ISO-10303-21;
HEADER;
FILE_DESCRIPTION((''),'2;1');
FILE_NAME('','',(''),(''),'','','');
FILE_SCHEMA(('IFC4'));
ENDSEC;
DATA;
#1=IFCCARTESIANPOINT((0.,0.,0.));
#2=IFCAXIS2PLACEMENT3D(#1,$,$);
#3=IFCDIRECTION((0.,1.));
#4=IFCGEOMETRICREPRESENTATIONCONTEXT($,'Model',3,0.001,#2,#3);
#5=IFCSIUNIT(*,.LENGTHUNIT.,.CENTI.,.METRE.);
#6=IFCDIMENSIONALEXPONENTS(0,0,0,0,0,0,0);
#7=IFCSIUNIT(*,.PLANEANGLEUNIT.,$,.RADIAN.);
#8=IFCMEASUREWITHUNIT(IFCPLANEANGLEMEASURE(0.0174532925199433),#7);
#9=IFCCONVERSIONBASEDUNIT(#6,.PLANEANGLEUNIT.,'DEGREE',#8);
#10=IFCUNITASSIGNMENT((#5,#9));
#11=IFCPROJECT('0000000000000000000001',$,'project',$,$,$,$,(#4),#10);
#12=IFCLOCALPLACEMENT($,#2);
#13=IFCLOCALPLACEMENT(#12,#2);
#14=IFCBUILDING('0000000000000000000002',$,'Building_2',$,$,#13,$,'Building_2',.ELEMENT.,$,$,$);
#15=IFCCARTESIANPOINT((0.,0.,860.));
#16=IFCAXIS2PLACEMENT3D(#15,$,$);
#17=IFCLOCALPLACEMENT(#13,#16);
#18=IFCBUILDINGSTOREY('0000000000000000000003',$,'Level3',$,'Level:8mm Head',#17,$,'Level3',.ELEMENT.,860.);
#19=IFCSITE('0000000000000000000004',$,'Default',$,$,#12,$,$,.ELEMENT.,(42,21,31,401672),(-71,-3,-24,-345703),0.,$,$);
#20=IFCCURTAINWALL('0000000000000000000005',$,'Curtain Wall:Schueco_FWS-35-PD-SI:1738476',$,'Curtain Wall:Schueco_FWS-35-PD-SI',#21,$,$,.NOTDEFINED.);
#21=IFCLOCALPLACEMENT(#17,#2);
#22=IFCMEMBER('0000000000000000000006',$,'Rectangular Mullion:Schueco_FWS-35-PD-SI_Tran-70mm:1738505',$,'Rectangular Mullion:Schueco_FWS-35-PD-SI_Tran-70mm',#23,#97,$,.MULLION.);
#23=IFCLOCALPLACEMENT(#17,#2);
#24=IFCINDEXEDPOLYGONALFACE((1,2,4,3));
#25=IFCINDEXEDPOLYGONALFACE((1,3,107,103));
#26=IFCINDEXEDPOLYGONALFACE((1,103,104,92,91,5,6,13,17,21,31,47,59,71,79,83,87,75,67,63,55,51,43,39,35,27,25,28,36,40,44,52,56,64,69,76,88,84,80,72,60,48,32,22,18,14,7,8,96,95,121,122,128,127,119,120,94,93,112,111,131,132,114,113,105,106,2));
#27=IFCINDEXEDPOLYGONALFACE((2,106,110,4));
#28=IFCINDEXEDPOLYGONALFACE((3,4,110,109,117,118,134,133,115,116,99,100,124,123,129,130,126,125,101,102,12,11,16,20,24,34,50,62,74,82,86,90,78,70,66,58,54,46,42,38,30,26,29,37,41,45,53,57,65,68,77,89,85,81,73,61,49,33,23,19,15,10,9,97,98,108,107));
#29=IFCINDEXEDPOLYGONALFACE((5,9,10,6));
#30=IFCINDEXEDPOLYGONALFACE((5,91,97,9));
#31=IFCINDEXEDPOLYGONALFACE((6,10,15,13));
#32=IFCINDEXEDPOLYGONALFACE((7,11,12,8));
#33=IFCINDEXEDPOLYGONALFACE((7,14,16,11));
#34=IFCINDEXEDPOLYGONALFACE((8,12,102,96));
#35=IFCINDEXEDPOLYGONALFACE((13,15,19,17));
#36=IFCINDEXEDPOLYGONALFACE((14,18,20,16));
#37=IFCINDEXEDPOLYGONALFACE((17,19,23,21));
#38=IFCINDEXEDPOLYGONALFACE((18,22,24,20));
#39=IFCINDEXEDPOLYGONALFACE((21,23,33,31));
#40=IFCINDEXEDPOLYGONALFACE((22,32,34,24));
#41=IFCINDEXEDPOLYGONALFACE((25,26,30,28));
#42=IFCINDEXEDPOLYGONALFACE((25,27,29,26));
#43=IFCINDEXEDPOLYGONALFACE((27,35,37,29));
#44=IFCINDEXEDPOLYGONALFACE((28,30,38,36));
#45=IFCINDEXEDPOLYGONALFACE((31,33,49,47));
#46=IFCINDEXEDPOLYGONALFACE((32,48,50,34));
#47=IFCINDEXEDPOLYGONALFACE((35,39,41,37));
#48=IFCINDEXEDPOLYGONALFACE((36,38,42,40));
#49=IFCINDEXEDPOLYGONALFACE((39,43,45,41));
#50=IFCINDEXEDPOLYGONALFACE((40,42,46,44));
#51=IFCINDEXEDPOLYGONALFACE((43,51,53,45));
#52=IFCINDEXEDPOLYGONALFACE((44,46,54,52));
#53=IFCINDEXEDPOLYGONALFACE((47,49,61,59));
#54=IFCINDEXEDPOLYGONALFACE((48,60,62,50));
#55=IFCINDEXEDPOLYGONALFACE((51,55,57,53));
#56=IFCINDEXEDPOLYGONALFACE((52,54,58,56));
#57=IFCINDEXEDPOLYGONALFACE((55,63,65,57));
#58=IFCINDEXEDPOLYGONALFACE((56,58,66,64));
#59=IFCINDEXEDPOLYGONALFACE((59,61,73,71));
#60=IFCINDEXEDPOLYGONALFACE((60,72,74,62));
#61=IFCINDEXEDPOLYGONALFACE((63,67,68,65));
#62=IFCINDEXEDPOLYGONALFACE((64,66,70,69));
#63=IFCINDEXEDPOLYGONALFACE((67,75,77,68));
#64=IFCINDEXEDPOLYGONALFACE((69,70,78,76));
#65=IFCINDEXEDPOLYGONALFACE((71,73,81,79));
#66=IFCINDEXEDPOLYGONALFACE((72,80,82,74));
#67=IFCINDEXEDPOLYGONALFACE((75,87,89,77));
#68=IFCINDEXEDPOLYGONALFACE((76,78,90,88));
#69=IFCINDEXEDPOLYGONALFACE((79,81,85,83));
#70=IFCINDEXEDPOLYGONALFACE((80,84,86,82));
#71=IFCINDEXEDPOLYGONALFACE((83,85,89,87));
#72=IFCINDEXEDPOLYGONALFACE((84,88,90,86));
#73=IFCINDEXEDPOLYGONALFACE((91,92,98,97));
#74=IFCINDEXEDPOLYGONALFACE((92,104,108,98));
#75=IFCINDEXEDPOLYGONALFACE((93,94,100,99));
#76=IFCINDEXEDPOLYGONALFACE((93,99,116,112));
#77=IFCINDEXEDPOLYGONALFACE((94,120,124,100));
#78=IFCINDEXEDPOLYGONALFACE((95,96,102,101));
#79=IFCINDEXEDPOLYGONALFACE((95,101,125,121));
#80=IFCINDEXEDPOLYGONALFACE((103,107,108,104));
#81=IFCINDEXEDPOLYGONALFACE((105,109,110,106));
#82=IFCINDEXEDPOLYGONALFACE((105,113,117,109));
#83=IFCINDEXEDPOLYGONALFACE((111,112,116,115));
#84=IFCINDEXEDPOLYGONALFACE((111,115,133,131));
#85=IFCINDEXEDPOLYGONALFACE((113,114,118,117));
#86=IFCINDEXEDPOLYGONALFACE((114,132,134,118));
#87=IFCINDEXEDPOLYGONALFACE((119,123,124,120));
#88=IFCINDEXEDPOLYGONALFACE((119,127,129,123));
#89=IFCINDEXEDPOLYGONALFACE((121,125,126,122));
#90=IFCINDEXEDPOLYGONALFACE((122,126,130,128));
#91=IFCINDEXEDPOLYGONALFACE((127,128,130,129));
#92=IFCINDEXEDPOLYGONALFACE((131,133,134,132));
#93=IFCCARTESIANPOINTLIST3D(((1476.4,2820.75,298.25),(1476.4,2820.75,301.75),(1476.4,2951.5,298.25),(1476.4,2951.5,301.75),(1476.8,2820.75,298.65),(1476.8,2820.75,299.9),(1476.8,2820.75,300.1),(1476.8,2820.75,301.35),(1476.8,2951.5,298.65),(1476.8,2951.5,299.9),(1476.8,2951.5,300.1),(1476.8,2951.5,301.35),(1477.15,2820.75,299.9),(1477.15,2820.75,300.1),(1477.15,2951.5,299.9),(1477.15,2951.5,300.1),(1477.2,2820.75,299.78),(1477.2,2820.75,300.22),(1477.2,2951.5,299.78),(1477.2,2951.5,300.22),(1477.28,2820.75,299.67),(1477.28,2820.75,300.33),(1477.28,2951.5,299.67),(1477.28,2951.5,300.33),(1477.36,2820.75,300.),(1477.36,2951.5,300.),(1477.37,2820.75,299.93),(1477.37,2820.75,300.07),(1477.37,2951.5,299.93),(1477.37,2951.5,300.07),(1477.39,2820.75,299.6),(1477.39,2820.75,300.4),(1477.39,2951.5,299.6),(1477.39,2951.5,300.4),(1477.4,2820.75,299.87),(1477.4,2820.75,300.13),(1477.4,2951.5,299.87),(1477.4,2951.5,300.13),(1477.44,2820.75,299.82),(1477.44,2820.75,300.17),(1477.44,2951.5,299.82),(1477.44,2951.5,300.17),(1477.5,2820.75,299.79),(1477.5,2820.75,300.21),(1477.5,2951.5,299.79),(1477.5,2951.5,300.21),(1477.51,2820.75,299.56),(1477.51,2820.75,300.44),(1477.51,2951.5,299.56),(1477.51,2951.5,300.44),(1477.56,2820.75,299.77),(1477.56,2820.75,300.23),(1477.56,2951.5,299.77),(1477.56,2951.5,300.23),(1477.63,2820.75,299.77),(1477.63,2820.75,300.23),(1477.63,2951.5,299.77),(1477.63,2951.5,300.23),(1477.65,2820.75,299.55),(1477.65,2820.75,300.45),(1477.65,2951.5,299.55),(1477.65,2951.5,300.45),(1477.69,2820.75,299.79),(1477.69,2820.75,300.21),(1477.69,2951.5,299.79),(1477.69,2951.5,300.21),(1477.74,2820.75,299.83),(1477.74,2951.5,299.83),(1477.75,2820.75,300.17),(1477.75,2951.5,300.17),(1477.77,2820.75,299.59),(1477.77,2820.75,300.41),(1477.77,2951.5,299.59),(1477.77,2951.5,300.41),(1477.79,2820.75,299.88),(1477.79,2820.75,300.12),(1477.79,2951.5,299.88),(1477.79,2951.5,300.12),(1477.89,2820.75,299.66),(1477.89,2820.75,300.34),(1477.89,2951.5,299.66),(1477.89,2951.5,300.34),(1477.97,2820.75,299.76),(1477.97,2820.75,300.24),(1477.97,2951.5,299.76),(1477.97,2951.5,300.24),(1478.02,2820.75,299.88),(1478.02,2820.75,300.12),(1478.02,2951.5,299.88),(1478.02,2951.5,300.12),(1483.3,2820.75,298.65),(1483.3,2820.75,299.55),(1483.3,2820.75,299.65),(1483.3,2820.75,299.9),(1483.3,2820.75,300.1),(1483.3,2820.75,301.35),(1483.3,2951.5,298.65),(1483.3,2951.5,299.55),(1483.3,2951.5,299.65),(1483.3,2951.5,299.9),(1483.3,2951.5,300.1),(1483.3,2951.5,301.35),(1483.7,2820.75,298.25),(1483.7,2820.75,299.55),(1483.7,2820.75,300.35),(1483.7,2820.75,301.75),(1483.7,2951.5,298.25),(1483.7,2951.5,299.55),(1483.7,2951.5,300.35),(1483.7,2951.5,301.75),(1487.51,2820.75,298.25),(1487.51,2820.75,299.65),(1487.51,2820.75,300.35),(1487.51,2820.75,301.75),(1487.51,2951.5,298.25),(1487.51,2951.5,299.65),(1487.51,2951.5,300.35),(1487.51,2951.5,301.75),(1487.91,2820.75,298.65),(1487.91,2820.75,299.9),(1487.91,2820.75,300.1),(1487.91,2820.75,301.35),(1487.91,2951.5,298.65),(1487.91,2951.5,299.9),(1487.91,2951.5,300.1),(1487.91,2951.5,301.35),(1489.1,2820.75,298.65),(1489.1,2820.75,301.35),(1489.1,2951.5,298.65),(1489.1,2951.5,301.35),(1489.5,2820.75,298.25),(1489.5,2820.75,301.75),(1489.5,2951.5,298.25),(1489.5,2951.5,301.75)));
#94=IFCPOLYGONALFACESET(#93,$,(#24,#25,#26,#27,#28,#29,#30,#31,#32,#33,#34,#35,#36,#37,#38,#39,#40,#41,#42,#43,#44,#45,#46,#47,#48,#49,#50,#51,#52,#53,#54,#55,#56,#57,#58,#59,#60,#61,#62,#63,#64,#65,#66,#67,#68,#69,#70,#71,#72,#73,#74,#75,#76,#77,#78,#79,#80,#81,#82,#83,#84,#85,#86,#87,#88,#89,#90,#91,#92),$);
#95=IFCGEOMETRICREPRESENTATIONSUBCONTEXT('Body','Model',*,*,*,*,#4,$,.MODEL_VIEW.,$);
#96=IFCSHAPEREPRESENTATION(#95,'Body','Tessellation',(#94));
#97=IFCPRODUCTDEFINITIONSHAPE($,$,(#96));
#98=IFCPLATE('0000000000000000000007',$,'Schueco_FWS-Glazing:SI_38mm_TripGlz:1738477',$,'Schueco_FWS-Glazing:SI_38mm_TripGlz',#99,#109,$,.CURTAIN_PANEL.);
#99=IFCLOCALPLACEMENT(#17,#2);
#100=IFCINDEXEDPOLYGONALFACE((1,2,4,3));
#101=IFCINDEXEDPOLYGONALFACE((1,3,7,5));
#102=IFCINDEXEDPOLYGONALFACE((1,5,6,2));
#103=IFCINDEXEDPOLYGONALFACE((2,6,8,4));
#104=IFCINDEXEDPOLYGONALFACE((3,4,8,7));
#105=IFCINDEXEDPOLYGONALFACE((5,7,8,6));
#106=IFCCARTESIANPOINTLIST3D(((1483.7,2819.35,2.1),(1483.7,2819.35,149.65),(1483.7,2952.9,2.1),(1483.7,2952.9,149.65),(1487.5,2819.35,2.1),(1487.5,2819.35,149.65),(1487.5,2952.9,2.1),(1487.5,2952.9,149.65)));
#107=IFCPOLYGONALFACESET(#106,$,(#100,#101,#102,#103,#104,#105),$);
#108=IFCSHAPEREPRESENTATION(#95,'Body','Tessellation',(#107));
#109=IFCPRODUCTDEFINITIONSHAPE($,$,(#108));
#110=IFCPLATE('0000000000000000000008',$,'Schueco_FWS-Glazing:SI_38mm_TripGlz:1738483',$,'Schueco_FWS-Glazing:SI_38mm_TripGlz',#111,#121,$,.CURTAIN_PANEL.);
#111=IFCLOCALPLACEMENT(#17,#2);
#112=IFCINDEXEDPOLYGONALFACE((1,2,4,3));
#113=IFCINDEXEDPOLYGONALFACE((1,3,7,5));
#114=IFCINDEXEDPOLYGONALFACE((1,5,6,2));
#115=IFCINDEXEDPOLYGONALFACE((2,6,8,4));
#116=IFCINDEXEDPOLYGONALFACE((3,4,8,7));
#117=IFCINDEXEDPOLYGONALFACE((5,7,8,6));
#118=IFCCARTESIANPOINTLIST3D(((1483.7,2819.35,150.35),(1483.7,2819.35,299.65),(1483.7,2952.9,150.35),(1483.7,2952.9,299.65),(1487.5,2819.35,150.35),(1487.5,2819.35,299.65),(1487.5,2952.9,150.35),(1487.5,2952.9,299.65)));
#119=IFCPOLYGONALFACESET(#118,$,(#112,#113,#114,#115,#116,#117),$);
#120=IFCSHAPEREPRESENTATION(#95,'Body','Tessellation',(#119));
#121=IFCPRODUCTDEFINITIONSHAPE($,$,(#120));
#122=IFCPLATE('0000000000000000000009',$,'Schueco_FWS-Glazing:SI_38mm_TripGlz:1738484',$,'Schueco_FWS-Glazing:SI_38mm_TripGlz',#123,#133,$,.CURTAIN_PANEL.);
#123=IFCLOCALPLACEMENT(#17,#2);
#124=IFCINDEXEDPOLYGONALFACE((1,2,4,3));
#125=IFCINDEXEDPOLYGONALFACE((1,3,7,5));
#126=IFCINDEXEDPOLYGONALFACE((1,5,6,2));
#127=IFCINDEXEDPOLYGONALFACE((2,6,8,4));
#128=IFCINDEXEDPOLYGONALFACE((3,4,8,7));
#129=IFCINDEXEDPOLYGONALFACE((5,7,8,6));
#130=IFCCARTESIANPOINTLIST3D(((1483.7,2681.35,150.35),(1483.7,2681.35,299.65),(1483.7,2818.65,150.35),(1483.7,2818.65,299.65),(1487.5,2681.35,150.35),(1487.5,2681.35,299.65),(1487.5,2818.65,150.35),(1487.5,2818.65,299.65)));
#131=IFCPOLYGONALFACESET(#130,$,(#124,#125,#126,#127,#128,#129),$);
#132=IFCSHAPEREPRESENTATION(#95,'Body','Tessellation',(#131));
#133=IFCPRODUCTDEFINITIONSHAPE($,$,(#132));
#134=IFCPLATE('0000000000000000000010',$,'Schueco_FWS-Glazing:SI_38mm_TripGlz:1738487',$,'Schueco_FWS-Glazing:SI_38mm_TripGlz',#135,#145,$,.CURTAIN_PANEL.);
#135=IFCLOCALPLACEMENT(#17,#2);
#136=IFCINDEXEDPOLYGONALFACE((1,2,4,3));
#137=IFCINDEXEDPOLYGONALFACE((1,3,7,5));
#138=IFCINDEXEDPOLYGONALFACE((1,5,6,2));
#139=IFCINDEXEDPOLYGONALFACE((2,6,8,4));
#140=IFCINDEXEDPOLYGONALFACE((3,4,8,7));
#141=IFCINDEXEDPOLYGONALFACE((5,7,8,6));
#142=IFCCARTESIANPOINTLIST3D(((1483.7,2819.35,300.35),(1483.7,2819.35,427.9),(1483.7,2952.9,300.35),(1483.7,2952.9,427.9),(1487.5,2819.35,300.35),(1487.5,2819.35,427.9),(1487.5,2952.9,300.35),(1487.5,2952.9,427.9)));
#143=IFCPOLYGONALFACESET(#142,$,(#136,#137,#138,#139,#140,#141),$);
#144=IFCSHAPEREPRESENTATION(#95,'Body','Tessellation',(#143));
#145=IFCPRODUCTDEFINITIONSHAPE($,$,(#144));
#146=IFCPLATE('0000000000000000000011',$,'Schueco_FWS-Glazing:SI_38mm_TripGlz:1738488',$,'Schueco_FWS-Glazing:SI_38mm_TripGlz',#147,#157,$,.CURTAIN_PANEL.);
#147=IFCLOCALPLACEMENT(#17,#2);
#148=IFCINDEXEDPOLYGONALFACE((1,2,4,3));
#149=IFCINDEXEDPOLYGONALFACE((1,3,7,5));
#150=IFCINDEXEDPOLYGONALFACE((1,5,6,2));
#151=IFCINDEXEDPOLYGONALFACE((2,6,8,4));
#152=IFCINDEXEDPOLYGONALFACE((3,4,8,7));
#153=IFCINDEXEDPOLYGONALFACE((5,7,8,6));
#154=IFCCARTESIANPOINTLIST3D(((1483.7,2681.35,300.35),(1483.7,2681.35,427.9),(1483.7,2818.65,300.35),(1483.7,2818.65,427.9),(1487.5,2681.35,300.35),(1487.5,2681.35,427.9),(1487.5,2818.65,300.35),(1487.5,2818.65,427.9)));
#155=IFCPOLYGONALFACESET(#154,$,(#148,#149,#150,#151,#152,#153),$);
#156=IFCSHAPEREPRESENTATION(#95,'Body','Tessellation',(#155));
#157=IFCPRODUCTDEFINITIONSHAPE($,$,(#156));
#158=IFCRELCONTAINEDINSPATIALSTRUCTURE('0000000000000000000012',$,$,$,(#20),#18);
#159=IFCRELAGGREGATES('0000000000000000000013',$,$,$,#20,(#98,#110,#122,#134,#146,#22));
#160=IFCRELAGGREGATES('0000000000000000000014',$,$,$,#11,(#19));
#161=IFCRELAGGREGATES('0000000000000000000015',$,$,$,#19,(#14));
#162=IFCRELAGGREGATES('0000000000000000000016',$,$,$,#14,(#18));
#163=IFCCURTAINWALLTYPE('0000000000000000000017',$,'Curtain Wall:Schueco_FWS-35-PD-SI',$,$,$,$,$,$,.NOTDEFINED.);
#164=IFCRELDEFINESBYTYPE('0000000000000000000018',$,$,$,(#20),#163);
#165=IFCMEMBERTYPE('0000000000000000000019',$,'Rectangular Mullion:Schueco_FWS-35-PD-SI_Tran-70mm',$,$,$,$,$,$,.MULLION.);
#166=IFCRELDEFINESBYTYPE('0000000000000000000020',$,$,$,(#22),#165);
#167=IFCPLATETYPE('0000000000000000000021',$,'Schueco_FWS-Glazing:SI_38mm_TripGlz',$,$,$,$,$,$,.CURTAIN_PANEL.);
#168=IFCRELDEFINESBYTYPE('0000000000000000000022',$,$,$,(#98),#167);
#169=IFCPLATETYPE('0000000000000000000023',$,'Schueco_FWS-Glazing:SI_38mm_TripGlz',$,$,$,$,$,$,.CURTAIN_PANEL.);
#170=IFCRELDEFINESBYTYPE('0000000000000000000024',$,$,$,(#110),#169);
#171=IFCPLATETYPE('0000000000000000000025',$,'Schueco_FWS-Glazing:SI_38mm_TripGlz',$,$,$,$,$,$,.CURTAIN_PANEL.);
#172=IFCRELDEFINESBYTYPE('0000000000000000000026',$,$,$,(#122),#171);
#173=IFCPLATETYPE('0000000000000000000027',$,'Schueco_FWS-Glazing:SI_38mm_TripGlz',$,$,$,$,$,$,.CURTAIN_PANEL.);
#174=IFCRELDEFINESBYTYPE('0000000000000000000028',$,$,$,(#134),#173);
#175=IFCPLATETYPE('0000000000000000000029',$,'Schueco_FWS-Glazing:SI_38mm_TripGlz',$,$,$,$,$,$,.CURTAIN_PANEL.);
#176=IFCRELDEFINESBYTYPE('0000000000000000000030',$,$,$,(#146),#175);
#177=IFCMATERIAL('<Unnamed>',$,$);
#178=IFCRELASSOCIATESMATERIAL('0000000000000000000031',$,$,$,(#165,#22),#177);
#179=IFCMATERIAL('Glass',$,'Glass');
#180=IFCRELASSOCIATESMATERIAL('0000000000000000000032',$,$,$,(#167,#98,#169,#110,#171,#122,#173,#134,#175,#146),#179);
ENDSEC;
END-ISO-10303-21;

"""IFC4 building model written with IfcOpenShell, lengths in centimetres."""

from ifc_helpers import new_model, entity, si_unit, converted_unit, direction, frame, origin, place, context, subcontext, project, spatial, line, arc, indexed_curve, outline, extrude, source, transform, mapped, material, type_object, type_shapes, element, aggregate, save


model = new_model("IFC4")

# Units and contexts
model_context = context("Model", 3, precision=0.001, world=origin(), true_north=direction((0.0, 1.0)))
body_context = subcontext(model_context, "Body", "Model", "MODEL_VIEW")
ifc_project = project(units=[si_unit("LENGTHUNIT", "METRE", prefix="CENTI"), converted_unit("PLANEANGLEUNIT", "DEGREE", entity("IfcPlaneAngleMeasure", 0.0174532925199433), si_unit("PLANEANGLEUNIT", "RADIAN"), dimensions=[0, 0, 0, 0, 0, 0, 0])], contexts=[model_context])

# Site, building, storey
site_placement = place(None, origin())
site = spatial("IfcSite", under=ifc_project, at=site_placement, Name="Default", CompositionType="ELEMENT", RefLatitude=(42, 21, 31, 401672), RefLongitude=(-71, -3, -24, -345703), RefElevation=0.0)
building_placement = place(site_placement, origin())
building = spatial("IfcBuilding", under=site, at=building_placement, Name="Building_2", LongName="Building_2", CompositionType="ELEMENT")
storey_placement = place(building_placement, frame((0.0, 0.0, 860.0)))
storey = spatial("IfcBuildingStorey", under=building, at=storey_placement, Name="Level3", ObjectType="Level:8mm Head", LongName="Level3", CompositionType="ELEMENT", Elevation=860.0)

# Curtain wall, member, plates
curtain_wall_type = type_object("IfcCurtainWallType", Name="Curtain Wall:Schueco_FWS-35-PD-SI", PredefinedType="NOTDEFINED")
curtain_wall_placement = place(storey_placement, frame((0.0, 0.0, -860.0)))
curtain_wall = element("IfcCurtainWall", 1, at=curtain_wall_placement, inside=storey, type_object=curtain_wall_type, Name="Curtain Wall:Schueco_FWS-35-PD-SI:1738476", ObjectType="Curtain Wall:Schueco_FWS-35-PD-SI", PredefinedType="NOTDEFINED")
ifc_material_1 = material(Name="<Unnamed>")
member_type_1 = type_object("IfcMemberType", Name="Rectangular Mullion:Schueco_FWS-35-PD-SI_Tran-70mm", PredefinedType="MULLION", material=ifc_material_1)
shared_shape_1 = source(origin(), body_context, "Body", "SweptSolid", [
    extrude(outline(indexed_curve([(-1.78, -6.52), (1.72, -6.52), (1.72, 0.78), (0.42, 0.78), (0.42, 0.38), (1.32, 0.38), (1.32, -6.12), (0.07, -6.12), (0.07, -5.77), (0.42, -5.34), (0.09, -4.9), (0.09, -5.14), (-0.03, -5.56), (-0.15, -5.14), (-0.15, -4.9), (-0.48, -5.34), (-0.13, -5.77), (-0.13, -6.12), (-1.38, -6.12), (-1.38, 0.38), (-0.13, 0.38), (-0.13, 4.99), (-1.38, 4.99), (-1.38, 6.18), (1.32, 6.18), (1.32, 4.99), (0.07, 4.99), (0.07, 0.38), (0.32, 0.38), (0.32, 4.59), (1.72, 4.59), (1.72, 6.58), (-1.78, 6.58), (-1.78, 4.59), (-0.38, 4.59), (-0.38, 0.78), (-1.78, 0.78)], segments=[line(1, 2, 3, 4, 5, 6, 7, 8, 9), arc(9, 10, 11), line(11, 12), arc(12, 13, 14), line(14, 15), arc(15, 16, 17), line(17, 18, 19, 20, 21, 22, 23, 24, 25, 26, 27, 28, 29, 30, 31, 32, 33, 34, 35, 36, 37, 1)], self_intersect=False)), frame((-0.03, 4.58, -130.75), z_axis=(0.0, 0.0, 1.0), x_axis=(-1.0, 0.0, 0.0)), (0.0, 0.0, 1.0), 130.75),
])
type_shapes(member_type_1, [shared_shape_1])
member_1_placement = place(curtain_wall_placement, frame((1487.5, 2820.75, 1160.0), z_axis=(0.0, -1.0, 0.0), x_axis=(0.0, 0.0, 1.0)))
member_1 = element("IfcMember", 2, at=member_1_placement, type_object=member_type_1, material=ifc_material_1, Name="Rectangular Mullion:Schueco_FWS-35-PD-SI_Tran-70mm:1738505", ObjectType="Rectangular Mullion:Schueco_FWS-35-PD-SI_Tran-70mm", PredefinedType="MULLION", context=body_context, shape_type="MappedRepresentation", body=[
    mapped(shared_shape_1, transform((0.0, 0.0, 0.0), scale=1.0)),
])
ifc_material_2 = material(Name="Glass", Category="Glass")
plate_type_1 = type_object("IfcPlateType", Name="Schueco_FWS-Glazing:SI_38mm_TripGlz", PredefinedType="CURTAIN_PANEL", material=ifc_material_2)
shared_shape_2 = source(origin(), body_context, "Body", "SweptSolid", [
    extrude(outline(indexed_curve([(-1.9, -66.78), (1.9, -66.78), (1.9, 66.78), (-1.9, 66.78), (-1.9, -66.78)], self_intersect=False)), frame((0.0, -1.9, 0.0), z_axis=(0.0, 0.0, 1.0), x_axis=(0.0, 1.0, 0.0)), (0.0, 0.0, 1.0), 147.55),
])
type_shapes(plate_type_1, [shared_shape_2])
plate_1_placement = place(curtain_wall_placement, frame((1487.5, 2886.12, 862.1), z_axis=(0.0, 0.0, 1.0), x_axis=(0.0, -1.0, 0.0)))
plate_1 = element("IfcPlate", 3, at=plate_1_placement, type_object=plate_type_1, material=ifc_material_2, Name="Schueco_FWS-Glazing:SI_38mm_TripGlz:1738477", ObjectType="Schueco_FWS-Glazing:SI_38mm_TripGlz", PredefinedType="CURTAIN_PANEL", context=body_context, shape_type="MappedRepresentation", body=[
    mapped(shared_shape_2, transform((0.0, 0.0, 0.0), scale=1.0)),
])
plate_type_2 = type_object("IfcPlateType", Name="Schueco_FWS-Glazing:SI_38mm_TripGlz", PredefinedType="CURTAIN_PANEL", material=ifc_material_2)
shared_shape_3 = source(origin(), body_context, "Body", "SweptSolid", [
    extrude(outline(indexed_curve([(-1.9, -66.78), (1.9, -66.78), (1.9, 66.78), (-1.9, 66.78), (-1.9, -66.78)], self_intersect=False)), frame((0.0, -1.9, 0.0), z_axis=(0.0, 0.0, 1.0), x_axis=(0.0, 1.0, 0.0)), (0.0, 0.0, 1.0), 149.3),
])
type_shapes(plate_type_2, [shared_shape_3])
plate_2_placement = place(curtain_wall_placement, frame((1487.5, 2886.12, 1010.35), z_axis=(0.0, 0.0, 1.0), x_axis=(0.0, -1.0, 0.0)))
plate_2 = element("IfcPlate", 4, at=plate_2_placement, type_object=plate_type_2, material=ifc_material_2, Name="Schueco_FWS-Glazing:SI_38mm_TripGlz:1738483", ObjectType="Schueco_FWS-Glazing:SI_38mm_TripGlz", PredefinedType="CURTAIN_PANEL", context=body_context, shape_type="MappedRepresentation", body=[
    mapped(shared_shape_3, transform((0.0, 0.0, 0.0), scale=1.0)),
])
plate_type_3 = type_object("IfcPlateType", Name="Schueco_FWS-Glazing:SI_38mm_TripGlz", PredefinedType="CURTAIN_PANEL", material=ifc_material_2)
shared_shape_4 = source(origin(), body_context, "Body", "SweptSolid", [
    extrude(outline(indexed_curve([(-1.9, -68.65), (1.9, -68.65), (1.9, 68.65), (-1.9, 68.65), (-1.9, -68.65)], self_intersect=False)), frame((0.0, -1.9, 0.0), z_axis=(0.0, 0.0, 1.0), x_axis=(0.0, 1.0, 0.0)), (0.0, 0.0, 1.0), 149.3),
])
type_shapes(plate_type_3, [shared_shape_4])
plate_3_placement = place(curtain_wall_placement, frame((1487.5, 2750.0, 1010.35), z_axis=(0.0, 0.0, 1.0), x_axis=(0.0, -1.0, 0.0)))
plate_3 = element("IfcPlate", 5, at=plate_3_placement, type_object=plate_type_3, material=ifc_material_2, Name="Schueco_FWS-Glazing:SI_38mm_TripGlz:1738484", ObjectType="Schueco_FWS-Glazing:SI_38mm_TripGlz", PredefinedType="CURTAIN_PANEL", context=body_context, shape_type="MappedRepresentation", body=[
    mapped(shared_shape_4, transform((0.0, 0.0, 0.0), scale=1.0)),
])
plate_type_4 = type_object("IfcPlateType", Name="Schueco_FWS-Glazing:SI_38mm_TripGlz", PredefinedType="CURTAIN_PANEL", material=ifc_material_2)
shared_shape_5 = source(origin(), body_context, "Body", "SweptSolid", [
    extrude(outline(indexed_curve([(-1.9, -66.78), (1.9, -66.78), (1.9, 66.78), (-1.9, 66.78), (-1.9, -66.78)], self_intersect=False)), frame((0.0, -1.9, 0.0), z_axis=(0.0, 0.0, 1.0), x_axis=(0.0, 1.0, 0.0)), (0.0, 0.0, 1.0), 127.55),
])
type_shapes(plate_type_4, [shared_shape_5])
plate_4_placement = place(curtain_wall_placement, frame((1487.5, 2886.12, 1160.35), z_axis=(0.0, 0.0, 1.0), x_axis=(0.0, -1.0, 0.0)))
plate_4 = element("IfcPlate", 6, at=plate_4_placement, type_object=plate_type_4, material=ifc_material_2, Name="Schueco_FWS-Glazing:SI_38mm_TripGlz:1738487", ObjectType="Schueco_FWS-Glazing:SI_38mm_TripGlz", PredefinedType="CURTAIN_PANEL", context=body_context, shape_type="MappedRepresentation", body=[
    mapped(shared_shape_5, transform((0.0, 0.0, 0.0), scale=1.0)),
])
plate_type_5 = type_object("IfcPlateType", Name="Schueco_FWS-Glazing:SI_38mm_TripGlz", PredefinedType="CURTAIN_PANEL", material=ifc_material_2)
shared_shape_6 = source(origin(), body_context, "Body", "SweptSolid", [
    extrude(outline(indexed_curve([(-1.9, -68.65), (1.9, -68.65), (1.9, 68.65), (-1.9, 68.65), (-1.9, -68.65)], self_intersect=False)), frame((0.0, -1.9, 0.0), z_axis=(0.0, 0.0, 1.0), x_axis=(0.0, 1.0, 0.0)), (0.0, 0.0, 1.0), 127.55),
])
type_shapes(plate_type_5, [shared_shape_6])
plate_5_placement = place(curtain_wall_placement, frame((1487.5, 2750.0, 1160.35), z_axis=(0.0, 0.0, 1.0), x_axis=(0.0, -1.0, 0.0)))
plate_5 = element("IfcPlate", 7, at=plate_5_placement, type_object=plate_type_5, material=ifc_material_2, Name="Schueco_FWS-Glazing:SI_38mm_TripGlz:1738488", ObjectType="Schueco_FWS-Glazing:SI_38mm_TripGlz", PredefinedType="CURTAIN_PANEL", context=body_context, shape_type="MappedRepresentation", body=[
    mapped(shared_shape_6, transform((0.0, 0.0, 0.0), scale=1.0)),
])
aggregate(curtain_wall, [plate_1, plate_2, plate_3, plate_4, plate_5, member_1])

save(model, "model.ifc")
